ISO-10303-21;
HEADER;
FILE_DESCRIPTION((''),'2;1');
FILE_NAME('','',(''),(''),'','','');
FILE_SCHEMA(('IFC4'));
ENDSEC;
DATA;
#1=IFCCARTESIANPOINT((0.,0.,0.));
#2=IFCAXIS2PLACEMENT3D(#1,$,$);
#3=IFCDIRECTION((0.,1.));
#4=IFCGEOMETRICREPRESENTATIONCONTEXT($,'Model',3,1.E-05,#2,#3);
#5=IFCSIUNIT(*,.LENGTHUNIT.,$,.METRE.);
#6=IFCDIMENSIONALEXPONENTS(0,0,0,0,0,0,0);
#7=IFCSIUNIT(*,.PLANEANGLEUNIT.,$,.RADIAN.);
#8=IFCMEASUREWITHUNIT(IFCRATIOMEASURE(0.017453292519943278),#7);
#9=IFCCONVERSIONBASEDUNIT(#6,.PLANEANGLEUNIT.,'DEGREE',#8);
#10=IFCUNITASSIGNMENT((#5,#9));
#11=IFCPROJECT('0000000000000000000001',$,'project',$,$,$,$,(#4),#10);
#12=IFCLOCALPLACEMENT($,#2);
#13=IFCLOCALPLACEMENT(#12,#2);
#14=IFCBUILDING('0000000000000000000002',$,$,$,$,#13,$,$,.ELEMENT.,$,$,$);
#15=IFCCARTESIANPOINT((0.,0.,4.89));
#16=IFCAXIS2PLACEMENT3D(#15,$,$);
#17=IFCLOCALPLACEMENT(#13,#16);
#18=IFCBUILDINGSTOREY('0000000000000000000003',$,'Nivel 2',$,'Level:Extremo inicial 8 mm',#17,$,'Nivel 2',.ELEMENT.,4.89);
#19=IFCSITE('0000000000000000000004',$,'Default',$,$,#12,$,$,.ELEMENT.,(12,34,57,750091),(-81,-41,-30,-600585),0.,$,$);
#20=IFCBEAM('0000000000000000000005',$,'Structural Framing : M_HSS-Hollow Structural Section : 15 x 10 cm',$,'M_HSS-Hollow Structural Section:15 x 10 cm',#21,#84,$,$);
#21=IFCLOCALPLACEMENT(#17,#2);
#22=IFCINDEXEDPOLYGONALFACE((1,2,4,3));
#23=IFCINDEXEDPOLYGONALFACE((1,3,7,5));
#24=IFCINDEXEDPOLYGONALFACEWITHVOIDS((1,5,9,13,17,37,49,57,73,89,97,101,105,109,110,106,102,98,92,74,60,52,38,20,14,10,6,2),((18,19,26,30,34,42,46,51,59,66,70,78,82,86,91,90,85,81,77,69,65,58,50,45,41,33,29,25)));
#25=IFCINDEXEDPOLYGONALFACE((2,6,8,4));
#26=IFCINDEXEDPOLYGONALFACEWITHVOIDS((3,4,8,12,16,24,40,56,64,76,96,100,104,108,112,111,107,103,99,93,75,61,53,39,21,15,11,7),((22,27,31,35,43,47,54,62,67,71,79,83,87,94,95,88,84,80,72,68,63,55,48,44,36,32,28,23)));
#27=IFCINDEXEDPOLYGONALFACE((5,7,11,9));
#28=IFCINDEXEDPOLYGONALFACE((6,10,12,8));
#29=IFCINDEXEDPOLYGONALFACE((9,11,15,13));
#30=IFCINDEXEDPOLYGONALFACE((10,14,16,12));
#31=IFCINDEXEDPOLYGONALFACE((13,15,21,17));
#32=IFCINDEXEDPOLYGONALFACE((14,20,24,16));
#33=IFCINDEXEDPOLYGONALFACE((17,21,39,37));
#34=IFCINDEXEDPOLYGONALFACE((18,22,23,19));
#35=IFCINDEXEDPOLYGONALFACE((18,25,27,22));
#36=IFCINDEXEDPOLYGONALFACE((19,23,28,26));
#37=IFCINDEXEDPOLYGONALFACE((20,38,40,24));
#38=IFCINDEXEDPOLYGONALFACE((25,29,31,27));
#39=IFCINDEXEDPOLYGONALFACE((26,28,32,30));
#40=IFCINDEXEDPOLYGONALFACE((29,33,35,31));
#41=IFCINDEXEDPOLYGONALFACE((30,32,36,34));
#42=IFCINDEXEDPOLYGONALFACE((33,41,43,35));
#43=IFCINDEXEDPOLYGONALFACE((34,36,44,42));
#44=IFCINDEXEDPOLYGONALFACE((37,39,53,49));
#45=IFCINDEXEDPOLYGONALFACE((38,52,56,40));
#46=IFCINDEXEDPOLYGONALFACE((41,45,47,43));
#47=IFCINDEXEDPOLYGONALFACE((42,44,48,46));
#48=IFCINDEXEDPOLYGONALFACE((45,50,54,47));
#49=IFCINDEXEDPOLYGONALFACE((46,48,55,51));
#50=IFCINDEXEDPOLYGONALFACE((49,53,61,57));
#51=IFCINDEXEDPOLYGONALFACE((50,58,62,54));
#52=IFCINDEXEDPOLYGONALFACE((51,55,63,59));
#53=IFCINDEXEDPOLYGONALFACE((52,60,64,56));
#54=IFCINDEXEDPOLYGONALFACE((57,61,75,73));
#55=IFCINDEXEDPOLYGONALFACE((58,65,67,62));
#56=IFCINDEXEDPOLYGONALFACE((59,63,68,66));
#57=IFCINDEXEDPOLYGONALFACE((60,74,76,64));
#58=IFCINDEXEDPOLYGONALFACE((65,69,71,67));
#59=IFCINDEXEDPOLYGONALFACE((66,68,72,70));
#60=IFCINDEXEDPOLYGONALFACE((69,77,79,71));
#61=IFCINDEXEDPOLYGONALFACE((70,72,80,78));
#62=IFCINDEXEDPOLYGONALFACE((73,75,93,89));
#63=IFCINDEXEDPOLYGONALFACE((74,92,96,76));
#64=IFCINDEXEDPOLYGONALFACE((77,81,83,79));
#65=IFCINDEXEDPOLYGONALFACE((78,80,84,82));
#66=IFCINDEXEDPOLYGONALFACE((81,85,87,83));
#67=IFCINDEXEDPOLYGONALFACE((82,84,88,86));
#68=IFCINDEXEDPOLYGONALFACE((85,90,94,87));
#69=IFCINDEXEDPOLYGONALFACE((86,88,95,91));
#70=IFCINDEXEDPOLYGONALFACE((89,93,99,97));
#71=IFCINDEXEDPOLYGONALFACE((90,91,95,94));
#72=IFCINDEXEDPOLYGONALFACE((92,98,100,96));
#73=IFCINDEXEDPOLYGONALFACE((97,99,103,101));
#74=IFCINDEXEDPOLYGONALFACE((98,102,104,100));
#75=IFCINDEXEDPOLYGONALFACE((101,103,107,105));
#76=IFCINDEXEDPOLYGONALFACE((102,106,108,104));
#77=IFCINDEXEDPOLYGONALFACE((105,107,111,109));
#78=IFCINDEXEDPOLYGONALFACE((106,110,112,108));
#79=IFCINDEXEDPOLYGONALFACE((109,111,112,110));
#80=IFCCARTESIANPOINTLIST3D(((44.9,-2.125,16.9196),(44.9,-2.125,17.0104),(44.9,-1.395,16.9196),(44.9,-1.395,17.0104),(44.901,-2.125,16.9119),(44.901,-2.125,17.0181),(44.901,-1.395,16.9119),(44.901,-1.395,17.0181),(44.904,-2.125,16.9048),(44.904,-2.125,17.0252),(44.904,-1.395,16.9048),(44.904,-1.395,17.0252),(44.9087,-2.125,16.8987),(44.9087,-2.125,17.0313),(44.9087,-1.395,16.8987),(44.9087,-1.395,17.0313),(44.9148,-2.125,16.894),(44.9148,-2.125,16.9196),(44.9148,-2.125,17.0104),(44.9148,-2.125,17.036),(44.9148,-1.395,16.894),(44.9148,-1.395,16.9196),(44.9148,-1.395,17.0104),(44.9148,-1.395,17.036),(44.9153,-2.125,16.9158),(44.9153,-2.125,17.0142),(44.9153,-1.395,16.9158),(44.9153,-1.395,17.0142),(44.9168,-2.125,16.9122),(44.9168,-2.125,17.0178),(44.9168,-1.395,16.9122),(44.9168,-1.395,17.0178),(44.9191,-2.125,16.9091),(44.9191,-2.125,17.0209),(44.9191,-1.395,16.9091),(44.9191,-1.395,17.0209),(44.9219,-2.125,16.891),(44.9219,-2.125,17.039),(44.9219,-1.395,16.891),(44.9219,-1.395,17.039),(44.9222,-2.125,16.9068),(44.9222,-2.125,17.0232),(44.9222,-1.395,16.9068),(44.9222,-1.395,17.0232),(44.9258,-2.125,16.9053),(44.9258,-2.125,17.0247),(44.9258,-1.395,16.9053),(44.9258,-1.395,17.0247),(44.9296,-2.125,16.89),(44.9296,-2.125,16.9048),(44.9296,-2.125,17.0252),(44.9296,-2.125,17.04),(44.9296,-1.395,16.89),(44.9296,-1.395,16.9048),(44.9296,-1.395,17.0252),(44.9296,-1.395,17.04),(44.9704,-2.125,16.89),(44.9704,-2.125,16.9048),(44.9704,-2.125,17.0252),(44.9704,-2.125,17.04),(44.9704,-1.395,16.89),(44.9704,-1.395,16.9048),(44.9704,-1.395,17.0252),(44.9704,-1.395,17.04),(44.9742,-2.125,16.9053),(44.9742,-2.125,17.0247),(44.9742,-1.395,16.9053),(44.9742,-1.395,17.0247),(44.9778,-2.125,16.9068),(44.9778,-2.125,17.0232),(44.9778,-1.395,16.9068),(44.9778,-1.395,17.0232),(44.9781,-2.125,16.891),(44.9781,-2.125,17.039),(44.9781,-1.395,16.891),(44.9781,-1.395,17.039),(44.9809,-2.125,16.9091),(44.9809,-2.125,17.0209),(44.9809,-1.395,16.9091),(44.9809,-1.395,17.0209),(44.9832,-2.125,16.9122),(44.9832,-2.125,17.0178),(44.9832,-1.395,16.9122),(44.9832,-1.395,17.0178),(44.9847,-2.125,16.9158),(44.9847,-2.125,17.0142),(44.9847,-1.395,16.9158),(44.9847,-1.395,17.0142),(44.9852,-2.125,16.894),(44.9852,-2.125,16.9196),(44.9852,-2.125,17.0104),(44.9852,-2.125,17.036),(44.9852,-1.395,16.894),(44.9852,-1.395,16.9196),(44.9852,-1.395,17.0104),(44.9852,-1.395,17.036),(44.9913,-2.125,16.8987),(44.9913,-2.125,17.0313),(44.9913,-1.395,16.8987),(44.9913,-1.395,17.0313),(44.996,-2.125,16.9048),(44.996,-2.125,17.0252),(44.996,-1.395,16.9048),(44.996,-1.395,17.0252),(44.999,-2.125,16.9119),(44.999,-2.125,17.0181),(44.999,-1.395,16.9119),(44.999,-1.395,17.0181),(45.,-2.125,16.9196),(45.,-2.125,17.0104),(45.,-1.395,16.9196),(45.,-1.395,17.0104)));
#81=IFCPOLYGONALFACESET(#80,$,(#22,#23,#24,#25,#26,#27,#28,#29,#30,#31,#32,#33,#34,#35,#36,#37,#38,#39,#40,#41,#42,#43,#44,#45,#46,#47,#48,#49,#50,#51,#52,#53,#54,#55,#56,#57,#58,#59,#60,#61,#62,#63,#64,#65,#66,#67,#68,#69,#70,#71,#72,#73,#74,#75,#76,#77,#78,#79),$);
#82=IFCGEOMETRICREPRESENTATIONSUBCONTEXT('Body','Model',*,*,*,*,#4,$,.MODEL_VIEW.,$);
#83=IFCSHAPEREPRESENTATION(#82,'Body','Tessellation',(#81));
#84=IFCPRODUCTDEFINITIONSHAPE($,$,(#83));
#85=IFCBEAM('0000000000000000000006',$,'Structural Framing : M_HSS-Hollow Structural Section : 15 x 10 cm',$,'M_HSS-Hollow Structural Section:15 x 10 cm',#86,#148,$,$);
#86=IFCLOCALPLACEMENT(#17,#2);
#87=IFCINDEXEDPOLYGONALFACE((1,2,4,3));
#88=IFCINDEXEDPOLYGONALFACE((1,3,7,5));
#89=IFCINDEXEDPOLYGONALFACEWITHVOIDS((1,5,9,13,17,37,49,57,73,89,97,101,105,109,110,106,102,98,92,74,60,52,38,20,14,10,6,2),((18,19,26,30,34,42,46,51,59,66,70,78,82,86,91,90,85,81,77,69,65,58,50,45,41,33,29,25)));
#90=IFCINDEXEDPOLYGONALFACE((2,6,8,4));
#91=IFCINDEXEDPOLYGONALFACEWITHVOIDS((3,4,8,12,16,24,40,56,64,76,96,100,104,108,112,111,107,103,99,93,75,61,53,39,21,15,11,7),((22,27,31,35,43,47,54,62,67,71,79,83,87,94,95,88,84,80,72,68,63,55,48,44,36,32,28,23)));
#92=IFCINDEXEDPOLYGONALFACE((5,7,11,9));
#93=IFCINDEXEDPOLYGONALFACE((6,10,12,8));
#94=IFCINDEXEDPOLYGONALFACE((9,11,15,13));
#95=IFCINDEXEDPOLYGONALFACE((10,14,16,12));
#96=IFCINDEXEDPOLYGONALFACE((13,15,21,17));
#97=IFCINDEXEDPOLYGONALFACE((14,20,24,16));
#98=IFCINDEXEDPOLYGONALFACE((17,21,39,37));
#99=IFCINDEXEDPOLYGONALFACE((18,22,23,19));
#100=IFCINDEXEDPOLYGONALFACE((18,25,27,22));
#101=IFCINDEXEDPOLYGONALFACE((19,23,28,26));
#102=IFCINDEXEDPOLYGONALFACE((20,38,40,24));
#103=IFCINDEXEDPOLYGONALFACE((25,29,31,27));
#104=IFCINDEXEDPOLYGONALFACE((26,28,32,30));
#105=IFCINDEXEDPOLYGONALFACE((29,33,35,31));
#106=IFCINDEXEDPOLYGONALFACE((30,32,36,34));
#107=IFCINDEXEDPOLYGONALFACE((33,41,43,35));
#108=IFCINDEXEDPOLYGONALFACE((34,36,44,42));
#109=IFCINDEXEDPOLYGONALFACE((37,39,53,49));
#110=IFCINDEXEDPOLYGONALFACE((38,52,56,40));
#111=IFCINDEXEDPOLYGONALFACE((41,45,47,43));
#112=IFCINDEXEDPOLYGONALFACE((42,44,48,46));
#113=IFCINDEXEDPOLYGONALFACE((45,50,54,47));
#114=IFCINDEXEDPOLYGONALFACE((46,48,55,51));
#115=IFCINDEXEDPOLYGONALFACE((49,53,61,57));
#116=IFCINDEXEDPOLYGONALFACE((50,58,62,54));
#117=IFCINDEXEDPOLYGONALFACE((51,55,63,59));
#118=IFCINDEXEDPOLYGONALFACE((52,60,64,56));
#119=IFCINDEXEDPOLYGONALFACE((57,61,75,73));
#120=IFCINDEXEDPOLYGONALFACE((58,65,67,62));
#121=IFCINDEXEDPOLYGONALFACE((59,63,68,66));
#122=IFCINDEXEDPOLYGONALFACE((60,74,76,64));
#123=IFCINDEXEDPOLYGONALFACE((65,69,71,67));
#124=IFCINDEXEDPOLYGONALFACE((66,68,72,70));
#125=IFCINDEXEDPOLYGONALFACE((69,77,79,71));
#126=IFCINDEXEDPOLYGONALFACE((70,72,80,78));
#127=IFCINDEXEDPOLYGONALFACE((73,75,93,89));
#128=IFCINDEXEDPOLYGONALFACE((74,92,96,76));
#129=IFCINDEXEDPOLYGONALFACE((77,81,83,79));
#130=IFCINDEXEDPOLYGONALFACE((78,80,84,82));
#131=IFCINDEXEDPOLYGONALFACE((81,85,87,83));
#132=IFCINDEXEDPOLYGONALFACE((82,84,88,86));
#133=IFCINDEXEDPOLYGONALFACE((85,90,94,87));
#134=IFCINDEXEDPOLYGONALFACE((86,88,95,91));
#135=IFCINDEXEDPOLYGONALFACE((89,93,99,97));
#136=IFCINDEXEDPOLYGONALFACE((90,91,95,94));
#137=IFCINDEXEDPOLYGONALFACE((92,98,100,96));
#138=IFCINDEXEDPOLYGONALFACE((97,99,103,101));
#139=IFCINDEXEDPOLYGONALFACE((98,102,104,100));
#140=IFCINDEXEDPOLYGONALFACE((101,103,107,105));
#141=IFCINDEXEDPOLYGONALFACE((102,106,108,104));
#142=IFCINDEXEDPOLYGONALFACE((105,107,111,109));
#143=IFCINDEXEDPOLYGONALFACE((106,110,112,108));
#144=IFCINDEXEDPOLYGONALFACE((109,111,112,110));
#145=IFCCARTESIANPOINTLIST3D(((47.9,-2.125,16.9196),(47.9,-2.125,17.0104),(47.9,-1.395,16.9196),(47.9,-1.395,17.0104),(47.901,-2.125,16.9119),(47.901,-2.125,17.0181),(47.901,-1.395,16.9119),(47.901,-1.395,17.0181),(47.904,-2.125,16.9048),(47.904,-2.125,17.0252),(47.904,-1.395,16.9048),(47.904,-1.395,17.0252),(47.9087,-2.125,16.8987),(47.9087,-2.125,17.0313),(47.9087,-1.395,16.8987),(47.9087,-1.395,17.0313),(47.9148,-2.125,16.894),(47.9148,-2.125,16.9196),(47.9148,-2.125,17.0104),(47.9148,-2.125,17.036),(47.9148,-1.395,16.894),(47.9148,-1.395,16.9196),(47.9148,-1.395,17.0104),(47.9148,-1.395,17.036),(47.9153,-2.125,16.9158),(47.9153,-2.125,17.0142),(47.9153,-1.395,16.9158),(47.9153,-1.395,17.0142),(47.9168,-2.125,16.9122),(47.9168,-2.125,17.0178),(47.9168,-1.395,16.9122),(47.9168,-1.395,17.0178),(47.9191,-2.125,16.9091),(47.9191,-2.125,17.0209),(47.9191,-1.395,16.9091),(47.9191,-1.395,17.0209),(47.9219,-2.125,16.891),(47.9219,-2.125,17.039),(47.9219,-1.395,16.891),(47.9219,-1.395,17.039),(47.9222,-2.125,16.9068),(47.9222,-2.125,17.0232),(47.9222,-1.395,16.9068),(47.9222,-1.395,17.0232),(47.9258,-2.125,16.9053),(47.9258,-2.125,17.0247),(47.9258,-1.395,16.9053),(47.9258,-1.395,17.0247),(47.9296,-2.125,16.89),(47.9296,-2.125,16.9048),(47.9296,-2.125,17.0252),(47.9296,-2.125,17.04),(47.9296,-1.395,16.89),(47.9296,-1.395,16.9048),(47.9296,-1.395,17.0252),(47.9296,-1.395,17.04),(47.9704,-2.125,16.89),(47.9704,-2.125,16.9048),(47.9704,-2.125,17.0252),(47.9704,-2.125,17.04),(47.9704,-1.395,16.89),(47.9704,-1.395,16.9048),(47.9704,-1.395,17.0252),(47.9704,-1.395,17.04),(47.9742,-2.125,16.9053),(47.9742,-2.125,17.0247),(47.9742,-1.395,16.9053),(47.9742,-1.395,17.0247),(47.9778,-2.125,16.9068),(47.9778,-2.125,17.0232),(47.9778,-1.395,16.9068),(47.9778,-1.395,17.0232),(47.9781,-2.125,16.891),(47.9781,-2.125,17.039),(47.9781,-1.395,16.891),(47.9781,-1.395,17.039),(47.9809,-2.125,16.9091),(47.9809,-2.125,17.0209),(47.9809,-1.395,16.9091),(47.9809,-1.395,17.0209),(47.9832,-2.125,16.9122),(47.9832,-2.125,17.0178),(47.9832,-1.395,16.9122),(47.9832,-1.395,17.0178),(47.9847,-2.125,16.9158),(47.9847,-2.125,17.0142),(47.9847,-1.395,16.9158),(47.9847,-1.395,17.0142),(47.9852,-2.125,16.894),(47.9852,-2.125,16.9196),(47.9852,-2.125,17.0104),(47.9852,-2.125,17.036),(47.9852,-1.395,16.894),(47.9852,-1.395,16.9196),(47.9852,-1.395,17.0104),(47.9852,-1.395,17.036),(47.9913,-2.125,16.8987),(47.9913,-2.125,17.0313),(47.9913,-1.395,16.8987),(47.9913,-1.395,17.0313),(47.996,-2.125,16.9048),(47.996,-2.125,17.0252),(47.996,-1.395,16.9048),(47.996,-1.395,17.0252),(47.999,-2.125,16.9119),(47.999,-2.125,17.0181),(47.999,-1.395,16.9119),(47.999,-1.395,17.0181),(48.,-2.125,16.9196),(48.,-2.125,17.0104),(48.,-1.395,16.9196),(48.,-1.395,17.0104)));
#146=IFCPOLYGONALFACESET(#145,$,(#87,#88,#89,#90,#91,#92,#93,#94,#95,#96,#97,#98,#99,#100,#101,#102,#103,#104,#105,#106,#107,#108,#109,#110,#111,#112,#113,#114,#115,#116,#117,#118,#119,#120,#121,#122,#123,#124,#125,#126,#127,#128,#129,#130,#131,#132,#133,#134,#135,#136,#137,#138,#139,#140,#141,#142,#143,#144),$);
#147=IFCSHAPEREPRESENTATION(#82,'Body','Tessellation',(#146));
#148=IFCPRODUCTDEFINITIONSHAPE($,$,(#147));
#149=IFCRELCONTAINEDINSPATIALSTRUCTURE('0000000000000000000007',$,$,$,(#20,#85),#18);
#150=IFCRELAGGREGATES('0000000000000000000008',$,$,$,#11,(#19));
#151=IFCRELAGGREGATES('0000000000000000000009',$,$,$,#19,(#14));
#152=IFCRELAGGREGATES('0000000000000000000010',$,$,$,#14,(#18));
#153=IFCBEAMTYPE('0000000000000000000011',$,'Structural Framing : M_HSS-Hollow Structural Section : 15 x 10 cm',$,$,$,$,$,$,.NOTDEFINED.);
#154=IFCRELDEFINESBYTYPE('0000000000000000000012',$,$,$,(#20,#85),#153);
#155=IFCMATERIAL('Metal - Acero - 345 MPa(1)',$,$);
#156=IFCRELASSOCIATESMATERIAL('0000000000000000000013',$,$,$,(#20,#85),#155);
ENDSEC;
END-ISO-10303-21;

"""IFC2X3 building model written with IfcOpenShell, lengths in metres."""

from ifc_helpers import new_model, entity, si_unit, converted_unit, direction, frame, frame_2d, origin, place, context, subcontext, project, spatial, polyline, circle_curve, parameter, trimmed, segment, composite_curve, outline, extrude, material, type_object, element, save


model = new_model("IFC2X3")

# Units and contexts
model_context = context("Model", 3, precision=1e-05, world=origin(), true_north=direction((0.0, 1.0)))
body_context = subcontext(model_context, "Body", "Model", "MODEL_VIEW")
ifc_project = project(units=[si_unit("LENGTHUNIT", "METRE"), converted_unit("PLANEANGLEUNIT", "DEGREE", entity("IfcRatioMeasure", 0.017453292519943278), si_unit("PLANEANGLEUNIT", "RADIAN"), dimensions=[0, 0, 0, 0, 0, 0, 0])], contexts=[model_context])

# Site, building, storey
site_placement = place(None, origin())
site = spatial("IfcSite", under=ifc_project, at=site_placement, Name="Default", CompositionType="ELEMENT", RefLatitude=(12, 34, 57, 750091), RefLongitude=(-81, -41, -30, -600585), RefElevation=0.0)
building_placement = place(site_placement, origin())
building = spatial("IfcBuilding", under=site, at=building_placement, CompositionType="ELEMENT")
storey_placement = place(building_placement, frame((0.0, 0.0, 4.89)))
storey = spatial("IfcBuildingStorey", under=building, at=storey_placement, Name="Nivel 2", ObjectType="Level:Extremo inicial 8 mm", LongName="Nivel 2", CompositionType="ELEMENT", Elevation=4.89)

# Shared definitions
ifc_material_1 = material(Name="Metal - Acero - 345 MPa(1)")

# Beams
beam_type_1 = type_object("IfcBeamType", Name="Structural Framing : M_HSS-Hollow Structural Section : 15 x 10 cm", PredefinedType="NOTDEFINED")
beam_1_placement = place(storey_placement, frame((44.95, -2.475, 17.04), z_axis=(0.0, 0.0, 1.0), x_axis=(0.0, 1.0, 0.0)))
element("IfcBeam", 1, at=beam_1_placement, inside=storey, type_object=beam_type_1, material=ifc_material_1, Name="Structural Framing : M_HSS-Hollow Structural Section : 15 x 10 cm", ObjectType="M_HSS-Hollow Structural Section:15 x 10 cm", context=body_context, shape_type="SweptSolid", body=[
    extrude(outline(composite_curve([segment(trimmed(circle_curve(frame_2d((0.0454, -0.0204), x_axis=(1.0, 0.0)), 0.0296), [parameter(270.0)], [parameter(360.0)], True, "PARAMETER"), True, "CONTINUOUS"), segment(polyline([(0.075, -0.0204), (0.075, 0.0204)]), True, "CONTINUOUS"), segment(trimmed(circle_curve(frame_2d((0.0454, 0.0204), x_axis=(0.0, 1.0)), 0.0296), [parameter(270.0)], [parameter(0.0)], True, "PARAMETER"), True, "CONTINUOUS"), segment(polyline([(0.0454, 0.05), (-0.0454, 0.05)]), True, "CONTINUOUS"), segment(trimmed(circle_curve(frame_2d((-0.0454, 0.0204), x_axis=(-1.0, 0.0)), 0.0296), [parameter(270.0)], [parameter(0.0)], True, "PARAMETER"), True, "CONTINUOUS"), segment(polyline([(-0.075, 0.0204), (-0.075, -0.0204)]), True, "CONTINUOUS"), segment(trimmed(circle_curve(frame_2d((-0.0454, -0.0204), x_axis=(0.0, -1.0)), 0.0296), [parameter(270.0)], [parameter(0.0)], True, "PARAMETER"), True, "CONTINUOUS"), segment(polyline([(-0.0454, -0.05), (0.0454, -0.05)]), True, "CONTINUOUS")], self_intersect=False), holes=[composite_curve([segment(polyline([(0.0602, 0.0204), (0.0602, -0.0204)]), True, "CONTINUOUS"), segment(trimmed(circle_curve(frame_2d((0.0454, -0.0204), x_axis=(0.0, -1.0)), 0.0148), [parameter(0.0)], [parameter(90.0)], True, "PARAMETER"), False, "CONTINUOUS"), segment(polyline([(0.0454, -0.0352), (-0.0454, -0.0352)]), True, "CONTINUOUS"), segment(trimmed(circle_curve(frame_2d((-0.0454, -0.0204), x_axis=(-1.0, 0.0)), 0.0148), [parameter(0.0)], [parameter(90.0)], True, "PARAMETER"), False, "CONTINUOUS"), segment(polyline([(-0.0602, -0.0204), (-0.0602, 0.0204)]), True, "CONTINUOUS"), segment(trimmed(circle_curve(frame_2d((-0.0454, 0.0204), x_axis=(0.0, 1.0)), 0.0148), [parameter(0.0)], [parameter(90.0)], True, "PARAMETER"), False, "CONTINUOUS"), segment(polyline([(-0.0454, 0.0352), (0.0454, 0.0352)]), True, "CONTINUOUS"), segment(trimmed(circle_curve(frame_2d((0.0454, 0.0204), x_axis=(1.0, 0.0)), 0.0148), [parameter(0.0)], [parameter(90.0)], True, "PARAMETER"), False, "CONTINUOUS")], self_intersect=False)]), frame((0.35, 0.0, -0.075), z_axis=(1.0, 0.0, 0.0), x_axis=(0.0, 0.0, 1.0)), (0.0, 0.0, 1.0), 0.73),
])
beam_2_placement = place(storey_placement, frame((47.95, -2.475, 17.04), z_axis=(0.0, 0.0, 1.0), x_axis=(0.0, 1.0, 0.0)))
element("IfcBeam", 2, at=beam_2_placement, inside=storey, type_object=beam_type_1, material=ifc_material_1, Name="Structural Framing : M_HSS-Hollow Structural Section : 15 x 10 cm", ObjectType="M_HSS-Hollow Structural Section:15 x 10 cm", context=body_context, shape_type="SweptSolid", body=[
    extrude(outline(composite_curve([segment(trimmed(circle_curve(frame_2d((0.0454, -0.0204), x_axis=(1.0, 0.0)), 0.0296), [parameter(270.0)], [parameter(360.0)], True, "PARAMETER"), True, "CONTINUOUS"), segment(polyline([(0.075, -0.0204), (0.075, 0.0204)]), True, "CONTINUOUS"), segment(trimmed(circle_curve(frame_2d((0.0454, 0.0204), x_axis=(0.0, 1.0)), 0.0296), [parameter(270.0)], [parameter(0.0)], True, "PARAMETER"), True, "CONTINUOUS"), segment(polyline([(0.0454, 0.05), (-0.0454, 0.05)]), True, "CONTINUOUS"), segment(trimmed(circle_curve(frame_2d((-0.0454, 0.0204), x_axis=(-1.0, 0.0)), 0.0296), [parameter(270.0)], [parameter(0.0)], True, "PARAMETER"), True, "CONTINUOUS"), segment(polyline([(-0.075, 0.0204), (-0.075, -0.0204)]), True, "CONTINUOUS"), segment(trimmed(circle_curve(frame_2d((-0.0454, -0.0204), x_axis=(0.0, -1.0)), 0.0296), [parameter(270.0)], [parameter(0.0)], True, "PARAMETER"), True, "CONTINUOUS"), segment(polyline([(-0.0454, -0.05), (0.0454, -0.05)]), True, "CONTINUOUS")], self_intersect=False), holes=[composite_curve([segment(polyline([(0.0602, 0.0204), (0.0602, -0.0204)]), True, "CONTINUOUS"), segment(trimmed(circle_curve(frame_2d((0.0454, -0.0204), x_axis=(0.0, -1.0)), 0.0148), [parameter(0.0)], [parameter(90.0)], True, "PARAMETER"), False, "CONTINUOUS"), segment(polyline([(0.0454, -0.0352), (-0.0454, -0.0352)]), True, "CONTINUOUS"), segment(trimmed(circle_curve(frame_2d((-0.0454, -0.0204), x_axis=(-1.0, 0.0)), 0.0148), [parameter(0.0)], [parameter(90.0)], True, "PARAMETER"), False, "CONTINUOUS"), segment(polyline([(-0.0602, -0.0204), (-0.0602, 0.0204)]), True, "CONTINUOUS"), segment(trimmed(circle_curve(frame_2d((-0.0454, 0.0204), x_axis=(0.0, 1.0)), 0.0148), [parameter(0.0)], [parameter(90.0)], True, "PARAMETER"), False, "CONTINUOUS"), segment(polyline([(-0.0454, 0.0352), (0.0454, 0.0352)]), True, "CONTINUOUS"), segment(trimmed(circle_curve(frame_2d((0.0454, 0.0204), x_axis=(1.0, 0.0)), 0.0148), [parameter(0.0)], [parameter(90.0)], True, "PARAMETER"), False, "CONTINUOUS")], self_intersect=False)]), frame((0.35, 0.0, -0.075), z_axis=(1.0, 0.0, 0.0), x_axis=(0.0, 0.0, 1.0)), (0.0, 0.0, 1.0), 0.73),
])

save(model, "model.ifc")
